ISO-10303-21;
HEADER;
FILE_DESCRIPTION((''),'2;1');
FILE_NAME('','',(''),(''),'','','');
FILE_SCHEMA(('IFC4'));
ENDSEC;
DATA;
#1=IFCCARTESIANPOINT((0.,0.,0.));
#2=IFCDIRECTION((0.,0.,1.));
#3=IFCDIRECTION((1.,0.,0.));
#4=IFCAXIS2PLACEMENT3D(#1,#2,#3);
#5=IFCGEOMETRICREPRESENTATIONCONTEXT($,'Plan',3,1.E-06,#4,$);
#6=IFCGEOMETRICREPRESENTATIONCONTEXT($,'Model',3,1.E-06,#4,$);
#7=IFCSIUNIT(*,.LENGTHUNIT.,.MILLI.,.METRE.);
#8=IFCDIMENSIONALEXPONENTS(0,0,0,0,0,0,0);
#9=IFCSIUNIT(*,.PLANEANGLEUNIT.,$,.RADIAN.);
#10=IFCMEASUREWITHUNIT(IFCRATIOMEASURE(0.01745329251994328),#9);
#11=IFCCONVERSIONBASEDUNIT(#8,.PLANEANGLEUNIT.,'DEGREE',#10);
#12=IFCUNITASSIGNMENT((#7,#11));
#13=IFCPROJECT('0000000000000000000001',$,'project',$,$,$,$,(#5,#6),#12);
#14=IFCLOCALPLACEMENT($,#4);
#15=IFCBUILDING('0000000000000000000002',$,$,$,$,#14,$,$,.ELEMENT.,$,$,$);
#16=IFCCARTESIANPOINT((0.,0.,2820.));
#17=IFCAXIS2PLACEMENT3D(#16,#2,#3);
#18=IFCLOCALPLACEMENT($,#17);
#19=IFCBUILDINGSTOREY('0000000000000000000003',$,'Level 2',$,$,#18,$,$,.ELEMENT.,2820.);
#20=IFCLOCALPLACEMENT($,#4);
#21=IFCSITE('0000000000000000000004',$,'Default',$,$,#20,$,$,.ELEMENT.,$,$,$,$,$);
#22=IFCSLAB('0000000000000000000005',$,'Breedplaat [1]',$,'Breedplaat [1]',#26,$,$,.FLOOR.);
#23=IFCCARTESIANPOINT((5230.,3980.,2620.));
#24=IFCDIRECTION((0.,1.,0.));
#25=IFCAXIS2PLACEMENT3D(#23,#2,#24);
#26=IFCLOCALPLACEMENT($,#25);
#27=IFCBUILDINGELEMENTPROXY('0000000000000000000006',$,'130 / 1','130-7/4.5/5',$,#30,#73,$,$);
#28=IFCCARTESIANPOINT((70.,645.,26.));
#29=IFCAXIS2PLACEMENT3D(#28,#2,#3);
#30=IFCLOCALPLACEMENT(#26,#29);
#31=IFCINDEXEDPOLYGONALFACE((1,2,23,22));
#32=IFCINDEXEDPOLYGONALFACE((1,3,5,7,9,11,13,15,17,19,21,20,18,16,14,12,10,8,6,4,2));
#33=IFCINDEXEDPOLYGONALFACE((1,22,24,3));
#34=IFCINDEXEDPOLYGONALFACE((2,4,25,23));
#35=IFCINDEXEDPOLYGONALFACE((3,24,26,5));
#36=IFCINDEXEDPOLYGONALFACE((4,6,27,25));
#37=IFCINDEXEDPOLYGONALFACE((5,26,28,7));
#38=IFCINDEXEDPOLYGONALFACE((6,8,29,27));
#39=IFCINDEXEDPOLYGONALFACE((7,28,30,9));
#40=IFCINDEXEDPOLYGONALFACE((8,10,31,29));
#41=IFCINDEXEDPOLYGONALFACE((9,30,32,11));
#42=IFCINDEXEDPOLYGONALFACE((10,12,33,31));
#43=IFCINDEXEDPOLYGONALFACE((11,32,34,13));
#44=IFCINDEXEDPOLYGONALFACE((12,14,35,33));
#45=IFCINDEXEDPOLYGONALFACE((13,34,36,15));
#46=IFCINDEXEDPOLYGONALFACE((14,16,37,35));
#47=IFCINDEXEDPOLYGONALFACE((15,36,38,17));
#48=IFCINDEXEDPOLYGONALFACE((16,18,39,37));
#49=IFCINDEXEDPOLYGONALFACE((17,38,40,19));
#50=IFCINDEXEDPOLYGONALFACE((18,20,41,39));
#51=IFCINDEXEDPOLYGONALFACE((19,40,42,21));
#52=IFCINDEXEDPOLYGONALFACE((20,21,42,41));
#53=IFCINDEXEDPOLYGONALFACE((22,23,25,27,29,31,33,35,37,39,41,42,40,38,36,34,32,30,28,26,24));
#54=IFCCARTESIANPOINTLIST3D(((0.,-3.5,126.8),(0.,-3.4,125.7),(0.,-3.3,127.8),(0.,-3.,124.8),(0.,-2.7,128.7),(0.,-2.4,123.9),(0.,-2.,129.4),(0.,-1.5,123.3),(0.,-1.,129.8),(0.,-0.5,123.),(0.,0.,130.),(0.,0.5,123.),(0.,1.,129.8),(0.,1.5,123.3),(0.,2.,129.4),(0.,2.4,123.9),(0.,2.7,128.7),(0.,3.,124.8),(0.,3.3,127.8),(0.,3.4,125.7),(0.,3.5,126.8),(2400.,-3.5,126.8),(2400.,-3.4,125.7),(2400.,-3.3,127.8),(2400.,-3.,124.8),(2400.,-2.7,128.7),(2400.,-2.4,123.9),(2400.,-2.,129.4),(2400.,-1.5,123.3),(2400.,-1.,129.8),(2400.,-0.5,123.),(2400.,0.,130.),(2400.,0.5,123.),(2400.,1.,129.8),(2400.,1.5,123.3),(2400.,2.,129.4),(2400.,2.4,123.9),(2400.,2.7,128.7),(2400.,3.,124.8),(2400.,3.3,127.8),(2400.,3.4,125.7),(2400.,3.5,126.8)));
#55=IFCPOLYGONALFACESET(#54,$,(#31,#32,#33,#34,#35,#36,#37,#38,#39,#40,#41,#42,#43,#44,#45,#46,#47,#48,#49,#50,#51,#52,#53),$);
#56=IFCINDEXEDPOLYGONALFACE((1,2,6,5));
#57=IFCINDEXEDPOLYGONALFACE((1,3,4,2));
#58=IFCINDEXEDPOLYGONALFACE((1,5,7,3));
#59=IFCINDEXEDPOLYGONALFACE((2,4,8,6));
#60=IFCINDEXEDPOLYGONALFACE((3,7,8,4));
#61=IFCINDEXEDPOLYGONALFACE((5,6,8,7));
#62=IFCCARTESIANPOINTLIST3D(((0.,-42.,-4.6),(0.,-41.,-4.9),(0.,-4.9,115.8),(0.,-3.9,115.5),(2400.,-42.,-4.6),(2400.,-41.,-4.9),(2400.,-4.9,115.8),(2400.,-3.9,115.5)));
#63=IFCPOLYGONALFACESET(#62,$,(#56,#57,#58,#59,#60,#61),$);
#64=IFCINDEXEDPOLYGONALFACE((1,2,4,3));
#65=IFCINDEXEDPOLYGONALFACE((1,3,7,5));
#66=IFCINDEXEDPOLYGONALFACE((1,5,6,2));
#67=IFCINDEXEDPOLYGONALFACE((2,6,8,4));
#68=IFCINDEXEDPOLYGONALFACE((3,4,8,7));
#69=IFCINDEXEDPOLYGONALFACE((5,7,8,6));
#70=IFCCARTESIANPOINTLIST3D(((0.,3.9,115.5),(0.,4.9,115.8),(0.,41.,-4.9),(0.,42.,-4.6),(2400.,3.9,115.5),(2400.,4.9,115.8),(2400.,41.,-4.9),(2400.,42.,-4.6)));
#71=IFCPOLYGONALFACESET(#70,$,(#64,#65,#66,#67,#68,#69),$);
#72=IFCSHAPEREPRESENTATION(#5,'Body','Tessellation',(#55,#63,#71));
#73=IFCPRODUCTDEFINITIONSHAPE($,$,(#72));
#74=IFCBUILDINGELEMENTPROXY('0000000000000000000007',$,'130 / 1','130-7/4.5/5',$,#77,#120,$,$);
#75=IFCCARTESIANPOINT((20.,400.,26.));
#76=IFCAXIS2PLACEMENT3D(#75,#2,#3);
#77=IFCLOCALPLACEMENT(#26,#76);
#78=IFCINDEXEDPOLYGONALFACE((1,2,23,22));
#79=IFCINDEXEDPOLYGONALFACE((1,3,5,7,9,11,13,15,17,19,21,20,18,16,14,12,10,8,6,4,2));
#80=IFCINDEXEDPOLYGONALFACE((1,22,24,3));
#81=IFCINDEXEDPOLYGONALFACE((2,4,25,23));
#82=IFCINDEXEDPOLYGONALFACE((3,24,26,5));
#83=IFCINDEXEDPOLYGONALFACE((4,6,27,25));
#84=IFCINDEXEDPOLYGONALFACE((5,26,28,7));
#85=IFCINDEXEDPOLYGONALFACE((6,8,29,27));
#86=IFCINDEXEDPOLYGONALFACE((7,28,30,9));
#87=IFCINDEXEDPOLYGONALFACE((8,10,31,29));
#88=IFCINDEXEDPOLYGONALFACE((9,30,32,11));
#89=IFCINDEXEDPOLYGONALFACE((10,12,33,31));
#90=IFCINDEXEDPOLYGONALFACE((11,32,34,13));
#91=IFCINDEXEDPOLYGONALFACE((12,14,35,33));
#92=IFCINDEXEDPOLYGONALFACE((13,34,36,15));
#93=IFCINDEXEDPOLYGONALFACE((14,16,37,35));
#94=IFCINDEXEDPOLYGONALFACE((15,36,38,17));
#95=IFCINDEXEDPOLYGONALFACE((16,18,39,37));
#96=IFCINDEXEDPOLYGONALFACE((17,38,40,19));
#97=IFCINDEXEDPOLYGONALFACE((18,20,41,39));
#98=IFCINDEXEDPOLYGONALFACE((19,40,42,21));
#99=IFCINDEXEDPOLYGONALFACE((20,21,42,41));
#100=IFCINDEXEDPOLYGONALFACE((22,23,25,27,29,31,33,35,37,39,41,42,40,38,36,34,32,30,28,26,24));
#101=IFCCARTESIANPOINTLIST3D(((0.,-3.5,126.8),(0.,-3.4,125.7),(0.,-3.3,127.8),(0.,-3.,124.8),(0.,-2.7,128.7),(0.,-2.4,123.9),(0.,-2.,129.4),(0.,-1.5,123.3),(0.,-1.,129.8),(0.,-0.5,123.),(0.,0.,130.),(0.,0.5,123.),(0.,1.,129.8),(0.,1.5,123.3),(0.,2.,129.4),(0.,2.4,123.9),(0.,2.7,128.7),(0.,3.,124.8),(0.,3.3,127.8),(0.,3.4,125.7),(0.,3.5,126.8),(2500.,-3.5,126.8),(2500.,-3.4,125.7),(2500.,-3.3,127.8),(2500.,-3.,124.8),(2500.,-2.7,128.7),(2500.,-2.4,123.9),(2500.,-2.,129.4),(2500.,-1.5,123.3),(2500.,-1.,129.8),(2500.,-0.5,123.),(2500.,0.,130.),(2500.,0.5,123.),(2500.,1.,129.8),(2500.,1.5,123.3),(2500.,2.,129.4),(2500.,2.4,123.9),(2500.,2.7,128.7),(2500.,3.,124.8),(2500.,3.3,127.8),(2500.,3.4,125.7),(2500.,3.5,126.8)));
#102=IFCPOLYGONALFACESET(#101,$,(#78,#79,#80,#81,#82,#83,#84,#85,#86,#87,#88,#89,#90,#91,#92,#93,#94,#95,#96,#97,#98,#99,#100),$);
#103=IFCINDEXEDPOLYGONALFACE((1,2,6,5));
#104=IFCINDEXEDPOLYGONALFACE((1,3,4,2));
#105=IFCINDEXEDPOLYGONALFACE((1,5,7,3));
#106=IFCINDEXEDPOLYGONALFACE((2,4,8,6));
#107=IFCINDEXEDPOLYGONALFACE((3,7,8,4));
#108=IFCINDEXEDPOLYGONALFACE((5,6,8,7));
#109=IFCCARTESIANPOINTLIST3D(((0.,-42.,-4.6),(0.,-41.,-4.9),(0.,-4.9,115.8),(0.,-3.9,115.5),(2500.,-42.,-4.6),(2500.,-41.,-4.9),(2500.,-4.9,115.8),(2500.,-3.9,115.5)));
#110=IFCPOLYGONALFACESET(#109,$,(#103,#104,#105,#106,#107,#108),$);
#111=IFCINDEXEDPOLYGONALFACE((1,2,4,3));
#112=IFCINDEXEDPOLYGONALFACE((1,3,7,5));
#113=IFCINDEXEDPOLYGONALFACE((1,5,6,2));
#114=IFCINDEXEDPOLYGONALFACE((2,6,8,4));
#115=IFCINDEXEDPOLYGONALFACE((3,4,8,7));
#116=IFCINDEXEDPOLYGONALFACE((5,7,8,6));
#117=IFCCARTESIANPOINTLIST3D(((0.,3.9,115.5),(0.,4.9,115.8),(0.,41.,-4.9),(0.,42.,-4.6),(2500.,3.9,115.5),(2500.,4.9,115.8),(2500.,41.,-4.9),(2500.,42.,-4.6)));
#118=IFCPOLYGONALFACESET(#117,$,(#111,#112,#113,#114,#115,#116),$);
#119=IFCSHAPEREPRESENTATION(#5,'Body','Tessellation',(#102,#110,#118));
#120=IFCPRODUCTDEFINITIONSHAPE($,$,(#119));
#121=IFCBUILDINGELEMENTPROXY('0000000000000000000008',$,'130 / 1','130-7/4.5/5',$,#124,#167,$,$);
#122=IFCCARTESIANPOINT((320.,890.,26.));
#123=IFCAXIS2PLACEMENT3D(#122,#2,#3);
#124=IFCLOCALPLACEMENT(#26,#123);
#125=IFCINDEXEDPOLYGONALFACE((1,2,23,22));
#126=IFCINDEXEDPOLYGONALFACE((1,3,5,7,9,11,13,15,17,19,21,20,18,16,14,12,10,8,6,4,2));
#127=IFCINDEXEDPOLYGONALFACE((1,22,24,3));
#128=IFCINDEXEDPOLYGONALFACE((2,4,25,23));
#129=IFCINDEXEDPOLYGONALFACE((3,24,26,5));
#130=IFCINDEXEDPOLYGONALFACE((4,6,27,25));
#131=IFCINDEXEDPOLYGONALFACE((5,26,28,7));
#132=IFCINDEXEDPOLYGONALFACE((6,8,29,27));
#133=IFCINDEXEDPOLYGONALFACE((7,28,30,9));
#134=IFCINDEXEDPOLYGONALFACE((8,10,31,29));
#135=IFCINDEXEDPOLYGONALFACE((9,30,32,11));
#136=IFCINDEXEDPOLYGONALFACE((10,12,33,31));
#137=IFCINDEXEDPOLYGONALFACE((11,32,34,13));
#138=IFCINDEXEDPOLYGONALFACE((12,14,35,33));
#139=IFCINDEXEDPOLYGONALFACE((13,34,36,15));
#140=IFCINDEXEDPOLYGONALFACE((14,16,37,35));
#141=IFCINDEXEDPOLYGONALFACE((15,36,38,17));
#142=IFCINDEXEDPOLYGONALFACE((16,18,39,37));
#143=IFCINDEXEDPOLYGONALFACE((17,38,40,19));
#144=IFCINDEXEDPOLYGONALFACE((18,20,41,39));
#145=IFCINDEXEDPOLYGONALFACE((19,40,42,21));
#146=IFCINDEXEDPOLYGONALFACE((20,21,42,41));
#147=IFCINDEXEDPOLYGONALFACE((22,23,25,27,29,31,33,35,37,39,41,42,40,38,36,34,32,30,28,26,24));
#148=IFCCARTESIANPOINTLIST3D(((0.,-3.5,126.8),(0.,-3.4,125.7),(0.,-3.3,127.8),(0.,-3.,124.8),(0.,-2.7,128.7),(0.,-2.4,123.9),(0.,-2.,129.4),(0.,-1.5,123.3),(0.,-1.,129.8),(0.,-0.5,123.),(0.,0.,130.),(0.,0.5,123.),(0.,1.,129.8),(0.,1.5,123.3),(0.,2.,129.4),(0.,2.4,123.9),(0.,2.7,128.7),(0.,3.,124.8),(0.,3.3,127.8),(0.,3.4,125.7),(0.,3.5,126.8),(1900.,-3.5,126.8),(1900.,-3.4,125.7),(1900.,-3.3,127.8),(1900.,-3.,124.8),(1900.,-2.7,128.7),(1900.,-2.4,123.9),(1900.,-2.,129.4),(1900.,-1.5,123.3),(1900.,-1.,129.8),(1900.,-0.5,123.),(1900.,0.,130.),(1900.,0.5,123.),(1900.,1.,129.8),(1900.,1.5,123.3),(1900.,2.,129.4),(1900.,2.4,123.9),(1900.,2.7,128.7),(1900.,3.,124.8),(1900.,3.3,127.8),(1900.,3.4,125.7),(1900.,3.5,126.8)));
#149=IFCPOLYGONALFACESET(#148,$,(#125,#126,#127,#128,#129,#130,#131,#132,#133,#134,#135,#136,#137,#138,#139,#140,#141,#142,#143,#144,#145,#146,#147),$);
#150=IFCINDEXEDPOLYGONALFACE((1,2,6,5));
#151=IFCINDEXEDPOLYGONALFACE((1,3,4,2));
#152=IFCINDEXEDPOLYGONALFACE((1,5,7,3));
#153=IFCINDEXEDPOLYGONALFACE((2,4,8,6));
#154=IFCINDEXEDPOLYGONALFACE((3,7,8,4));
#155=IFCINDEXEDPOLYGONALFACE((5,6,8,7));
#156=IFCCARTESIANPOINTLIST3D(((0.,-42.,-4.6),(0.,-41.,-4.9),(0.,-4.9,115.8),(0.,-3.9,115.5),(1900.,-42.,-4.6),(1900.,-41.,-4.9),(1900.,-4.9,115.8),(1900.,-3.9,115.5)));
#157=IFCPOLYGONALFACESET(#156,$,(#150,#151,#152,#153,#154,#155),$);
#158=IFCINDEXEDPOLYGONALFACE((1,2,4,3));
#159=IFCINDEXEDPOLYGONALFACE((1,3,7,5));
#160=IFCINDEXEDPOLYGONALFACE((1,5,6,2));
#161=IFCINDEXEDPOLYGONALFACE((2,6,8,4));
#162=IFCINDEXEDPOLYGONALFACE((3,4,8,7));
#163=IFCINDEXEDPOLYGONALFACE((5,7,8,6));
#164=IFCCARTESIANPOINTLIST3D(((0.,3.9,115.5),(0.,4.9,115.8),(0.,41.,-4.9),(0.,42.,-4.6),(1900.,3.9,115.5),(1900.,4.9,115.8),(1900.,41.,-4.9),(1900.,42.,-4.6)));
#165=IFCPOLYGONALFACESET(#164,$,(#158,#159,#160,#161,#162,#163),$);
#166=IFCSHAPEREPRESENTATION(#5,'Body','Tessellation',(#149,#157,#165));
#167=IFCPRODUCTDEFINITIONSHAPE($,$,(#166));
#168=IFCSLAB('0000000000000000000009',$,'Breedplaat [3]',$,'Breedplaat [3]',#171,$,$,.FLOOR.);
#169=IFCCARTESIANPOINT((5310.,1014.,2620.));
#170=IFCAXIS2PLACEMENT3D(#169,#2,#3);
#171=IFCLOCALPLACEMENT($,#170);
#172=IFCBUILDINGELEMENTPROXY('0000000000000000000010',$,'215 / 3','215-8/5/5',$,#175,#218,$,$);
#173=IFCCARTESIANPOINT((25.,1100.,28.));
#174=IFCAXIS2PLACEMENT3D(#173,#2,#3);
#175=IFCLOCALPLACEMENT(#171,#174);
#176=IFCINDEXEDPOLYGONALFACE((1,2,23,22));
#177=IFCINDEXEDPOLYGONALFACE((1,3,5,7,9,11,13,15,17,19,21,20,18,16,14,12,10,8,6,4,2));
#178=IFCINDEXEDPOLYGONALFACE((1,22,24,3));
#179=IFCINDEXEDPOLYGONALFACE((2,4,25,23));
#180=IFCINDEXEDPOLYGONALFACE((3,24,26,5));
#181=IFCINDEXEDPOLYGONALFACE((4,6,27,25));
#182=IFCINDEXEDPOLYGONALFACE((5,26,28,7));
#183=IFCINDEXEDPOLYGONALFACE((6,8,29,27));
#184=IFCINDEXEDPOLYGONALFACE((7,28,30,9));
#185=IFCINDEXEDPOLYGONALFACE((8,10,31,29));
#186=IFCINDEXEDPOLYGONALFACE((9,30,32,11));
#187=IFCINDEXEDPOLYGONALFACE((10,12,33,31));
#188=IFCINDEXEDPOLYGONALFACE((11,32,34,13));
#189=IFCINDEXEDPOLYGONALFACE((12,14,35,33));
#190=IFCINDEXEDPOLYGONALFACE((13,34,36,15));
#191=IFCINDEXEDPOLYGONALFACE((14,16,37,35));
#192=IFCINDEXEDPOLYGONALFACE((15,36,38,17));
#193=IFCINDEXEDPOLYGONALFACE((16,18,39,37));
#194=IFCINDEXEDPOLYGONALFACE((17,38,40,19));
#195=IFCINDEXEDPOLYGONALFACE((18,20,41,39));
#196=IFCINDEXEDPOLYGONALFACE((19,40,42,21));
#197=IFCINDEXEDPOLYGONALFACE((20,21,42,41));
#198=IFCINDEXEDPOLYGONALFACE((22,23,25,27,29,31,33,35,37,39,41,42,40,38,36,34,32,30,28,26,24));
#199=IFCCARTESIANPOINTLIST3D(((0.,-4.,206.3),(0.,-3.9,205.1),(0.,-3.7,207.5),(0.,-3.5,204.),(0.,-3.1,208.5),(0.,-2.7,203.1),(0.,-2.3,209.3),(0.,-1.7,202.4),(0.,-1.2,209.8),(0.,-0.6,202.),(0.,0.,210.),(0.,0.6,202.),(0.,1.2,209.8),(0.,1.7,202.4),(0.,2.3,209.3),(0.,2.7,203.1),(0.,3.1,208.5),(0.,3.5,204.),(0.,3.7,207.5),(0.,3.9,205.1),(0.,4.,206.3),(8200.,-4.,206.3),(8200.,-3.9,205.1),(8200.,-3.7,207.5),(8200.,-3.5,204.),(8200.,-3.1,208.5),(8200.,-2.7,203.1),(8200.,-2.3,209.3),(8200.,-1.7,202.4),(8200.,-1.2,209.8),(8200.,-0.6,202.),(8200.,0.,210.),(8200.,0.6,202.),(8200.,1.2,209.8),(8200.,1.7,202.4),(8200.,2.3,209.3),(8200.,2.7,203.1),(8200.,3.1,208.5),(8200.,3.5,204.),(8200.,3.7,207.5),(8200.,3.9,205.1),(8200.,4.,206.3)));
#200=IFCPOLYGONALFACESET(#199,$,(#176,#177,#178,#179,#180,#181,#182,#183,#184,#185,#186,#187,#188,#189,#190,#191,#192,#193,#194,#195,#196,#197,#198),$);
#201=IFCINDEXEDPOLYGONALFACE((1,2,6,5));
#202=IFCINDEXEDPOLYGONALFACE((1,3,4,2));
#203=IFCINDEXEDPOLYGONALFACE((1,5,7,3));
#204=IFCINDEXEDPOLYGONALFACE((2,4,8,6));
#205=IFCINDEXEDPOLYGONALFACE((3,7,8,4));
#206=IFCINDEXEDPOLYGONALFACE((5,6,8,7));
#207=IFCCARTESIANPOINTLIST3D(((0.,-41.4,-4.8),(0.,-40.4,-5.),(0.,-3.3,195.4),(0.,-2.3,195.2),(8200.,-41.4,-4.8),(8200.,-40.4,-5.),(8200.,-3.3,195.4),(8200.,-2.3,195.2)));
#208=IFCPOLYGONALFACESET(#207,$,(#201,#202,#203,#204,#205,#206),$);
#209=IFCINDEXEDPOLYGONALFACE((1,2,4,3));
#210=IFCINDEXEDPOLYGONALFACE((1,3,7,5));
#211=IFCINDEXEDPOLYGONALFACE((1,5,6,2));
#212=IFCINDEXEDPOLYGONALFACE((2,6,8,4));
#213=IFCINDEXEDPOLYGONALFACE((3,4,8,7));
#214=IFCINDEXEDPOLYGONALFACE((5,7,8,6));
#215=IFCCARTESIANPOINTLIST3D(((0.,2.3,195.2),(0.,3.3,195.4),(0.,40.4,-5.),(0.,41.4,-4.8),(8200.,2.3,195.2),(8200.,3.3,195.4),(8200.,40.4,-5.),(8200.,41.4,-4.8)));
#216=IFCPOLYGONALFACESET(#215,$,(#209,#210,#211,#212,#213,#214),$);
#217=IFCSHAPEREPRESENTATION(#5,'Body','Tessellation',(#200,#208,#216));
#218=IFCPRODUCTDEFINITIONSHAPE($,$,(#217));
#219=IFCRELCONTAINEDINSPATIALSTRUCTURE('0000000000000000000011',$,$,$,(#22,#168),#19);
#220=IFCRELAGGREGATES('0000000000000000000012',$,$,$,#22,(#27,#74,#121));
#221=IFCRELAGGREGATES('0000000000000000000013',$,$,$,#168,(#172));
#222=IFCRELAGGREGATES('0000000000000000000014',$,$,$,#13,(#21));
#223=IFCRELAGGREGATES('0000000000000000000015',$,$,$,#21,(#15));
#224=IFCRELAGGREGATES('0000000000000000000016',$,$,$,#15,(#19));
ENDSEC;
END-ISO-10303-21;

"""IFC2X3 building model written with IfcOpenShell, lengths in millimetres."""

from ifc_helpers import new_model, entity, si_unit, converted_unit, frame, origin_with_axes, origin_2d_with_axis, place, context, project, spatial, rectangle, circle, extrude, element, aggregate, save


model = new_model("IFC2X3")

# Units and contexts
plan_context = context("Plan", 3, precision=1e-06, world=origin_with_axes())
model_context = context("Model", 3, precision=1e-06, world=origin_with_axes())
ifc_project = project(units=[si_unit("LENGTHUNIT", "METRE", prefix="MILLI"), converted_unit("PLANEANGLEUNIT", "DEGREE", entity("IfcRatioMeasure", 0.01745329251994328), si_unit("PLANEANGLEUNIT", "RADIAN"), dimensions=[0, 0, 0, 0, 0, 0, 0])], contexts=[plan_context, model_context])

# Site, building, storey
site_placement = place(None, origin_with_axes())
site = spatial("IfcSite", under=ifc_project, at=site_placement, Name="Default", CompositionType="ELEMENT")
building_placement = place(None, origin_with_axes())
building = spatial("IfcBuilding", under=site, at=building_placement, CompositionType="ELEMENT")
storey_placement = place(None, frame((0.0, 0.0, 2820.0), z_axis=(0.0, 0.0, 1.0), x_axis=(1.0, 0.0, 0.0)))
storey = spatial("IfcBuildingStorey", under=building, at=storey_placement, Name="Level 2", CompositionType="ELEMENT", Elevation=2820.0)

# Slab, building element proxies
slab_1_placement = place(None, frame((5230.0, 3980.0, 2620.0), z_axis=(0.0, 0.0, 1.0), x_axis=(0.0, 1.0, 0.0)))
slab_1 = element("IfcSlab", 1, at=slab_1_placement, inside=storey, Name="Breedplaat [1]", ObjectType="Breedplaat [1]", PredefinedType="FLOOR")
proxy_1_placement = place(slab_1_placement, frame((70.0, 645.0, 26.0), z_axis=(0.0, 0.0, 1.0), x_axis=(1.0, 0.0, 0.0)))
proxy_1 = element("IfcBuildingElementProxy", 2, at=proxy_1_placement, Name="130 / 1", Description="130-7/4.5/5", context=plan_context, shape_type="SweptSolid", body=[
    extrude(circle(Radius=3.5, at=origin_2d_with_axis()), frame((0.0, 0.0, 126.5), z_axis=(1.0, 0.0, 0.0), x_axis=(0.0, 0.0, 1.0)), (0.0, 0.0, 1.0), 2400.0),
    extrude(rectangle(XDim=126.0, YDim=1.0, at=origin_2d_with_axis()), frame((0.0, -22.9, 55.4), z_axis=(1.0, 0.0, 0.0), x_axis=(0.0, 0.294086, 0.955779)), (0.0, 0.0, 1.0), 2400.0),
    extrude(rectangle(XDim=126.0, YDim=1.0, at=origin_2d_with_axis()), frame((0.0, 22.9, 55.4), z_axis=(1.0, 0.0, 0.0), x_axis=(0.0, -0.294086, 0.955779)), (0.0, 0.0, 1.0), 2400.0),
])
proxy_2_placement = place(slab_1_placement, frame((20.0, 400.0, 26.0), z_axis=(0.0, 0.0, 1.0), x_axis=(1.0, 0.0, 0.0)))
proxy_2 = element("IfcBuildingElementProxy", 3, at=proxy_2_placement, Name="130 / 1", Description="130-7/4.5/5", context=plan_context, shape_type="SweptSolid", body=[
    extrude(circle(Radius=3.5, at=origin_2d_with_axis()), frame((0.0, 0.0, 126.5), z_axis=(1.0, 0.0, 0.0), x_axis=(0.0, 0.0, 1.0)), (0.0, 0.0, 1.0), 2500.0),
    extrude(rectangle(XDim=126.0, YDim=1.0, at=origin_2d_with_axis()), frame((0.0, -22.9, 55.4), z_axis=(1.0, 0.0, 0.0), x_axis=(0.0, 0.294086, 0.955779)), (0.0, 0.0, 1.0), 2500.0),
    extrude(rectangle(XDim=126.0, YDim=1.0, at=origin_2d_with_axis()), frame((0.0, 22.9, 55.4), z_axis=(1.0, 0.0, 0.0), x_axis=(0.0, -0.294086, 0.955779)), (0.0, 0.0, 1.0), 2500.0),
])
proxy_3_placement = place(slab_1_placement, frame((320.0, 890.0, 26.0), z_axis=(0.0, 0.0, 1.0), x_axis=(1.0, 0.0, 0.0)))
proxy_3 = element("IfcBuildingElementProxy", 4, at=proxy_3_placement, Name="130 / 1", Description="130-7/4.5/5", context=plan_context, shape_type="SweptSolid", body=[
    extrude(circle(Radius=3.5, at=origin_2d_with_axis()), frame((0.0, 0.0, 126.5), z_axis=(1.0, 0.0, 0.0), x_axis=(0.0, 0.0, 1.0)), (0.0, 0.0, 1.0), 1900.0),
    extrude(rectangle(XDim=126.0, YDim=1.0, at=origin_2d_with_axis()), frame((0.0, -22.9, 55.4), z_axis=(1.0, 0.0, 0.0), x_axis=(0.0, 0.294086, 0.955779)), (0.0, 0.0, 1.0), 1900.0),
    extrude(rectangle(XDim=126.0, YDim=1.0, at=origin_2d_with_axis()), frame((0.0, 22.9, 55.4), z_axis=(1.0, 0.0, 0.0), x_axis=(0.0, -0.294086, 0.955779)), (0.0, 0.0, 1.0), 1900.0),
])
aggregate(slab_1, [proxy_1, proxy_2, proxy_3])

# Slab, building element proxy
slab_2_placement = place(None, frame((5310.0, 1014.0, 2620.0), z_axis=(0.0, 0.0, 1.0), x_axis=(1.0, 0.0, 0.0)))
slab_2 = element("IfcSlab", 5, at=slab_2_placement, inside=storey, Name="Breedplaat [3]", ObjectType="Breedplaat [3]", PredefinedType="FLOOR")
proxy_4_placement = place(slab_2_placement, frame((25.0, 1100.0, 28.0), z_axis=(0.0, 0.0, 1.0), x_axis=(1.0, 0.0, 0.0)))
proxy_4 = element("IfcBuildingElementProxy", 6, at=proxy_4_placement, Name="215 / 3", Description="215-8/5/5", context=plan_context, shape_type="SweptSolid", body=[
    extrude(circle(Radius=4.0, at=origin_2d_with_axis()), frame((0.0, 0.0, 206.0), z_axis=(1.0, 0.0, 0.0), x_axis=(0.0, 0.0, 1.0)), (0.0, 0.0, 1.0), 8200.0),
    extrude(rectangle(XDim=203.8, YDim=1.0, at=origin_2d_with_axis()), frame((0.0, -21.9, 95.2), z_axis=(1.0, 0.0, 0.0), x_axis=(0.0, 0.187112, 0.982339)), (0.0, 0.0, 1.0), 8200.0),
    extrude(rectangle(XDim=203.8, YDim=1.0, at=origin_2d_with_axis()), frame((0.0, 21.9, 95.2), z_axis=(1.0, 0.0, 0.0), x_axis=(0.0, -0.187112, 0.982339)), (0.0, 0.0, 1.0), 8200.0),
])
aggregate(slab_2, [proxy_4])

save(model, "model.ifc")
